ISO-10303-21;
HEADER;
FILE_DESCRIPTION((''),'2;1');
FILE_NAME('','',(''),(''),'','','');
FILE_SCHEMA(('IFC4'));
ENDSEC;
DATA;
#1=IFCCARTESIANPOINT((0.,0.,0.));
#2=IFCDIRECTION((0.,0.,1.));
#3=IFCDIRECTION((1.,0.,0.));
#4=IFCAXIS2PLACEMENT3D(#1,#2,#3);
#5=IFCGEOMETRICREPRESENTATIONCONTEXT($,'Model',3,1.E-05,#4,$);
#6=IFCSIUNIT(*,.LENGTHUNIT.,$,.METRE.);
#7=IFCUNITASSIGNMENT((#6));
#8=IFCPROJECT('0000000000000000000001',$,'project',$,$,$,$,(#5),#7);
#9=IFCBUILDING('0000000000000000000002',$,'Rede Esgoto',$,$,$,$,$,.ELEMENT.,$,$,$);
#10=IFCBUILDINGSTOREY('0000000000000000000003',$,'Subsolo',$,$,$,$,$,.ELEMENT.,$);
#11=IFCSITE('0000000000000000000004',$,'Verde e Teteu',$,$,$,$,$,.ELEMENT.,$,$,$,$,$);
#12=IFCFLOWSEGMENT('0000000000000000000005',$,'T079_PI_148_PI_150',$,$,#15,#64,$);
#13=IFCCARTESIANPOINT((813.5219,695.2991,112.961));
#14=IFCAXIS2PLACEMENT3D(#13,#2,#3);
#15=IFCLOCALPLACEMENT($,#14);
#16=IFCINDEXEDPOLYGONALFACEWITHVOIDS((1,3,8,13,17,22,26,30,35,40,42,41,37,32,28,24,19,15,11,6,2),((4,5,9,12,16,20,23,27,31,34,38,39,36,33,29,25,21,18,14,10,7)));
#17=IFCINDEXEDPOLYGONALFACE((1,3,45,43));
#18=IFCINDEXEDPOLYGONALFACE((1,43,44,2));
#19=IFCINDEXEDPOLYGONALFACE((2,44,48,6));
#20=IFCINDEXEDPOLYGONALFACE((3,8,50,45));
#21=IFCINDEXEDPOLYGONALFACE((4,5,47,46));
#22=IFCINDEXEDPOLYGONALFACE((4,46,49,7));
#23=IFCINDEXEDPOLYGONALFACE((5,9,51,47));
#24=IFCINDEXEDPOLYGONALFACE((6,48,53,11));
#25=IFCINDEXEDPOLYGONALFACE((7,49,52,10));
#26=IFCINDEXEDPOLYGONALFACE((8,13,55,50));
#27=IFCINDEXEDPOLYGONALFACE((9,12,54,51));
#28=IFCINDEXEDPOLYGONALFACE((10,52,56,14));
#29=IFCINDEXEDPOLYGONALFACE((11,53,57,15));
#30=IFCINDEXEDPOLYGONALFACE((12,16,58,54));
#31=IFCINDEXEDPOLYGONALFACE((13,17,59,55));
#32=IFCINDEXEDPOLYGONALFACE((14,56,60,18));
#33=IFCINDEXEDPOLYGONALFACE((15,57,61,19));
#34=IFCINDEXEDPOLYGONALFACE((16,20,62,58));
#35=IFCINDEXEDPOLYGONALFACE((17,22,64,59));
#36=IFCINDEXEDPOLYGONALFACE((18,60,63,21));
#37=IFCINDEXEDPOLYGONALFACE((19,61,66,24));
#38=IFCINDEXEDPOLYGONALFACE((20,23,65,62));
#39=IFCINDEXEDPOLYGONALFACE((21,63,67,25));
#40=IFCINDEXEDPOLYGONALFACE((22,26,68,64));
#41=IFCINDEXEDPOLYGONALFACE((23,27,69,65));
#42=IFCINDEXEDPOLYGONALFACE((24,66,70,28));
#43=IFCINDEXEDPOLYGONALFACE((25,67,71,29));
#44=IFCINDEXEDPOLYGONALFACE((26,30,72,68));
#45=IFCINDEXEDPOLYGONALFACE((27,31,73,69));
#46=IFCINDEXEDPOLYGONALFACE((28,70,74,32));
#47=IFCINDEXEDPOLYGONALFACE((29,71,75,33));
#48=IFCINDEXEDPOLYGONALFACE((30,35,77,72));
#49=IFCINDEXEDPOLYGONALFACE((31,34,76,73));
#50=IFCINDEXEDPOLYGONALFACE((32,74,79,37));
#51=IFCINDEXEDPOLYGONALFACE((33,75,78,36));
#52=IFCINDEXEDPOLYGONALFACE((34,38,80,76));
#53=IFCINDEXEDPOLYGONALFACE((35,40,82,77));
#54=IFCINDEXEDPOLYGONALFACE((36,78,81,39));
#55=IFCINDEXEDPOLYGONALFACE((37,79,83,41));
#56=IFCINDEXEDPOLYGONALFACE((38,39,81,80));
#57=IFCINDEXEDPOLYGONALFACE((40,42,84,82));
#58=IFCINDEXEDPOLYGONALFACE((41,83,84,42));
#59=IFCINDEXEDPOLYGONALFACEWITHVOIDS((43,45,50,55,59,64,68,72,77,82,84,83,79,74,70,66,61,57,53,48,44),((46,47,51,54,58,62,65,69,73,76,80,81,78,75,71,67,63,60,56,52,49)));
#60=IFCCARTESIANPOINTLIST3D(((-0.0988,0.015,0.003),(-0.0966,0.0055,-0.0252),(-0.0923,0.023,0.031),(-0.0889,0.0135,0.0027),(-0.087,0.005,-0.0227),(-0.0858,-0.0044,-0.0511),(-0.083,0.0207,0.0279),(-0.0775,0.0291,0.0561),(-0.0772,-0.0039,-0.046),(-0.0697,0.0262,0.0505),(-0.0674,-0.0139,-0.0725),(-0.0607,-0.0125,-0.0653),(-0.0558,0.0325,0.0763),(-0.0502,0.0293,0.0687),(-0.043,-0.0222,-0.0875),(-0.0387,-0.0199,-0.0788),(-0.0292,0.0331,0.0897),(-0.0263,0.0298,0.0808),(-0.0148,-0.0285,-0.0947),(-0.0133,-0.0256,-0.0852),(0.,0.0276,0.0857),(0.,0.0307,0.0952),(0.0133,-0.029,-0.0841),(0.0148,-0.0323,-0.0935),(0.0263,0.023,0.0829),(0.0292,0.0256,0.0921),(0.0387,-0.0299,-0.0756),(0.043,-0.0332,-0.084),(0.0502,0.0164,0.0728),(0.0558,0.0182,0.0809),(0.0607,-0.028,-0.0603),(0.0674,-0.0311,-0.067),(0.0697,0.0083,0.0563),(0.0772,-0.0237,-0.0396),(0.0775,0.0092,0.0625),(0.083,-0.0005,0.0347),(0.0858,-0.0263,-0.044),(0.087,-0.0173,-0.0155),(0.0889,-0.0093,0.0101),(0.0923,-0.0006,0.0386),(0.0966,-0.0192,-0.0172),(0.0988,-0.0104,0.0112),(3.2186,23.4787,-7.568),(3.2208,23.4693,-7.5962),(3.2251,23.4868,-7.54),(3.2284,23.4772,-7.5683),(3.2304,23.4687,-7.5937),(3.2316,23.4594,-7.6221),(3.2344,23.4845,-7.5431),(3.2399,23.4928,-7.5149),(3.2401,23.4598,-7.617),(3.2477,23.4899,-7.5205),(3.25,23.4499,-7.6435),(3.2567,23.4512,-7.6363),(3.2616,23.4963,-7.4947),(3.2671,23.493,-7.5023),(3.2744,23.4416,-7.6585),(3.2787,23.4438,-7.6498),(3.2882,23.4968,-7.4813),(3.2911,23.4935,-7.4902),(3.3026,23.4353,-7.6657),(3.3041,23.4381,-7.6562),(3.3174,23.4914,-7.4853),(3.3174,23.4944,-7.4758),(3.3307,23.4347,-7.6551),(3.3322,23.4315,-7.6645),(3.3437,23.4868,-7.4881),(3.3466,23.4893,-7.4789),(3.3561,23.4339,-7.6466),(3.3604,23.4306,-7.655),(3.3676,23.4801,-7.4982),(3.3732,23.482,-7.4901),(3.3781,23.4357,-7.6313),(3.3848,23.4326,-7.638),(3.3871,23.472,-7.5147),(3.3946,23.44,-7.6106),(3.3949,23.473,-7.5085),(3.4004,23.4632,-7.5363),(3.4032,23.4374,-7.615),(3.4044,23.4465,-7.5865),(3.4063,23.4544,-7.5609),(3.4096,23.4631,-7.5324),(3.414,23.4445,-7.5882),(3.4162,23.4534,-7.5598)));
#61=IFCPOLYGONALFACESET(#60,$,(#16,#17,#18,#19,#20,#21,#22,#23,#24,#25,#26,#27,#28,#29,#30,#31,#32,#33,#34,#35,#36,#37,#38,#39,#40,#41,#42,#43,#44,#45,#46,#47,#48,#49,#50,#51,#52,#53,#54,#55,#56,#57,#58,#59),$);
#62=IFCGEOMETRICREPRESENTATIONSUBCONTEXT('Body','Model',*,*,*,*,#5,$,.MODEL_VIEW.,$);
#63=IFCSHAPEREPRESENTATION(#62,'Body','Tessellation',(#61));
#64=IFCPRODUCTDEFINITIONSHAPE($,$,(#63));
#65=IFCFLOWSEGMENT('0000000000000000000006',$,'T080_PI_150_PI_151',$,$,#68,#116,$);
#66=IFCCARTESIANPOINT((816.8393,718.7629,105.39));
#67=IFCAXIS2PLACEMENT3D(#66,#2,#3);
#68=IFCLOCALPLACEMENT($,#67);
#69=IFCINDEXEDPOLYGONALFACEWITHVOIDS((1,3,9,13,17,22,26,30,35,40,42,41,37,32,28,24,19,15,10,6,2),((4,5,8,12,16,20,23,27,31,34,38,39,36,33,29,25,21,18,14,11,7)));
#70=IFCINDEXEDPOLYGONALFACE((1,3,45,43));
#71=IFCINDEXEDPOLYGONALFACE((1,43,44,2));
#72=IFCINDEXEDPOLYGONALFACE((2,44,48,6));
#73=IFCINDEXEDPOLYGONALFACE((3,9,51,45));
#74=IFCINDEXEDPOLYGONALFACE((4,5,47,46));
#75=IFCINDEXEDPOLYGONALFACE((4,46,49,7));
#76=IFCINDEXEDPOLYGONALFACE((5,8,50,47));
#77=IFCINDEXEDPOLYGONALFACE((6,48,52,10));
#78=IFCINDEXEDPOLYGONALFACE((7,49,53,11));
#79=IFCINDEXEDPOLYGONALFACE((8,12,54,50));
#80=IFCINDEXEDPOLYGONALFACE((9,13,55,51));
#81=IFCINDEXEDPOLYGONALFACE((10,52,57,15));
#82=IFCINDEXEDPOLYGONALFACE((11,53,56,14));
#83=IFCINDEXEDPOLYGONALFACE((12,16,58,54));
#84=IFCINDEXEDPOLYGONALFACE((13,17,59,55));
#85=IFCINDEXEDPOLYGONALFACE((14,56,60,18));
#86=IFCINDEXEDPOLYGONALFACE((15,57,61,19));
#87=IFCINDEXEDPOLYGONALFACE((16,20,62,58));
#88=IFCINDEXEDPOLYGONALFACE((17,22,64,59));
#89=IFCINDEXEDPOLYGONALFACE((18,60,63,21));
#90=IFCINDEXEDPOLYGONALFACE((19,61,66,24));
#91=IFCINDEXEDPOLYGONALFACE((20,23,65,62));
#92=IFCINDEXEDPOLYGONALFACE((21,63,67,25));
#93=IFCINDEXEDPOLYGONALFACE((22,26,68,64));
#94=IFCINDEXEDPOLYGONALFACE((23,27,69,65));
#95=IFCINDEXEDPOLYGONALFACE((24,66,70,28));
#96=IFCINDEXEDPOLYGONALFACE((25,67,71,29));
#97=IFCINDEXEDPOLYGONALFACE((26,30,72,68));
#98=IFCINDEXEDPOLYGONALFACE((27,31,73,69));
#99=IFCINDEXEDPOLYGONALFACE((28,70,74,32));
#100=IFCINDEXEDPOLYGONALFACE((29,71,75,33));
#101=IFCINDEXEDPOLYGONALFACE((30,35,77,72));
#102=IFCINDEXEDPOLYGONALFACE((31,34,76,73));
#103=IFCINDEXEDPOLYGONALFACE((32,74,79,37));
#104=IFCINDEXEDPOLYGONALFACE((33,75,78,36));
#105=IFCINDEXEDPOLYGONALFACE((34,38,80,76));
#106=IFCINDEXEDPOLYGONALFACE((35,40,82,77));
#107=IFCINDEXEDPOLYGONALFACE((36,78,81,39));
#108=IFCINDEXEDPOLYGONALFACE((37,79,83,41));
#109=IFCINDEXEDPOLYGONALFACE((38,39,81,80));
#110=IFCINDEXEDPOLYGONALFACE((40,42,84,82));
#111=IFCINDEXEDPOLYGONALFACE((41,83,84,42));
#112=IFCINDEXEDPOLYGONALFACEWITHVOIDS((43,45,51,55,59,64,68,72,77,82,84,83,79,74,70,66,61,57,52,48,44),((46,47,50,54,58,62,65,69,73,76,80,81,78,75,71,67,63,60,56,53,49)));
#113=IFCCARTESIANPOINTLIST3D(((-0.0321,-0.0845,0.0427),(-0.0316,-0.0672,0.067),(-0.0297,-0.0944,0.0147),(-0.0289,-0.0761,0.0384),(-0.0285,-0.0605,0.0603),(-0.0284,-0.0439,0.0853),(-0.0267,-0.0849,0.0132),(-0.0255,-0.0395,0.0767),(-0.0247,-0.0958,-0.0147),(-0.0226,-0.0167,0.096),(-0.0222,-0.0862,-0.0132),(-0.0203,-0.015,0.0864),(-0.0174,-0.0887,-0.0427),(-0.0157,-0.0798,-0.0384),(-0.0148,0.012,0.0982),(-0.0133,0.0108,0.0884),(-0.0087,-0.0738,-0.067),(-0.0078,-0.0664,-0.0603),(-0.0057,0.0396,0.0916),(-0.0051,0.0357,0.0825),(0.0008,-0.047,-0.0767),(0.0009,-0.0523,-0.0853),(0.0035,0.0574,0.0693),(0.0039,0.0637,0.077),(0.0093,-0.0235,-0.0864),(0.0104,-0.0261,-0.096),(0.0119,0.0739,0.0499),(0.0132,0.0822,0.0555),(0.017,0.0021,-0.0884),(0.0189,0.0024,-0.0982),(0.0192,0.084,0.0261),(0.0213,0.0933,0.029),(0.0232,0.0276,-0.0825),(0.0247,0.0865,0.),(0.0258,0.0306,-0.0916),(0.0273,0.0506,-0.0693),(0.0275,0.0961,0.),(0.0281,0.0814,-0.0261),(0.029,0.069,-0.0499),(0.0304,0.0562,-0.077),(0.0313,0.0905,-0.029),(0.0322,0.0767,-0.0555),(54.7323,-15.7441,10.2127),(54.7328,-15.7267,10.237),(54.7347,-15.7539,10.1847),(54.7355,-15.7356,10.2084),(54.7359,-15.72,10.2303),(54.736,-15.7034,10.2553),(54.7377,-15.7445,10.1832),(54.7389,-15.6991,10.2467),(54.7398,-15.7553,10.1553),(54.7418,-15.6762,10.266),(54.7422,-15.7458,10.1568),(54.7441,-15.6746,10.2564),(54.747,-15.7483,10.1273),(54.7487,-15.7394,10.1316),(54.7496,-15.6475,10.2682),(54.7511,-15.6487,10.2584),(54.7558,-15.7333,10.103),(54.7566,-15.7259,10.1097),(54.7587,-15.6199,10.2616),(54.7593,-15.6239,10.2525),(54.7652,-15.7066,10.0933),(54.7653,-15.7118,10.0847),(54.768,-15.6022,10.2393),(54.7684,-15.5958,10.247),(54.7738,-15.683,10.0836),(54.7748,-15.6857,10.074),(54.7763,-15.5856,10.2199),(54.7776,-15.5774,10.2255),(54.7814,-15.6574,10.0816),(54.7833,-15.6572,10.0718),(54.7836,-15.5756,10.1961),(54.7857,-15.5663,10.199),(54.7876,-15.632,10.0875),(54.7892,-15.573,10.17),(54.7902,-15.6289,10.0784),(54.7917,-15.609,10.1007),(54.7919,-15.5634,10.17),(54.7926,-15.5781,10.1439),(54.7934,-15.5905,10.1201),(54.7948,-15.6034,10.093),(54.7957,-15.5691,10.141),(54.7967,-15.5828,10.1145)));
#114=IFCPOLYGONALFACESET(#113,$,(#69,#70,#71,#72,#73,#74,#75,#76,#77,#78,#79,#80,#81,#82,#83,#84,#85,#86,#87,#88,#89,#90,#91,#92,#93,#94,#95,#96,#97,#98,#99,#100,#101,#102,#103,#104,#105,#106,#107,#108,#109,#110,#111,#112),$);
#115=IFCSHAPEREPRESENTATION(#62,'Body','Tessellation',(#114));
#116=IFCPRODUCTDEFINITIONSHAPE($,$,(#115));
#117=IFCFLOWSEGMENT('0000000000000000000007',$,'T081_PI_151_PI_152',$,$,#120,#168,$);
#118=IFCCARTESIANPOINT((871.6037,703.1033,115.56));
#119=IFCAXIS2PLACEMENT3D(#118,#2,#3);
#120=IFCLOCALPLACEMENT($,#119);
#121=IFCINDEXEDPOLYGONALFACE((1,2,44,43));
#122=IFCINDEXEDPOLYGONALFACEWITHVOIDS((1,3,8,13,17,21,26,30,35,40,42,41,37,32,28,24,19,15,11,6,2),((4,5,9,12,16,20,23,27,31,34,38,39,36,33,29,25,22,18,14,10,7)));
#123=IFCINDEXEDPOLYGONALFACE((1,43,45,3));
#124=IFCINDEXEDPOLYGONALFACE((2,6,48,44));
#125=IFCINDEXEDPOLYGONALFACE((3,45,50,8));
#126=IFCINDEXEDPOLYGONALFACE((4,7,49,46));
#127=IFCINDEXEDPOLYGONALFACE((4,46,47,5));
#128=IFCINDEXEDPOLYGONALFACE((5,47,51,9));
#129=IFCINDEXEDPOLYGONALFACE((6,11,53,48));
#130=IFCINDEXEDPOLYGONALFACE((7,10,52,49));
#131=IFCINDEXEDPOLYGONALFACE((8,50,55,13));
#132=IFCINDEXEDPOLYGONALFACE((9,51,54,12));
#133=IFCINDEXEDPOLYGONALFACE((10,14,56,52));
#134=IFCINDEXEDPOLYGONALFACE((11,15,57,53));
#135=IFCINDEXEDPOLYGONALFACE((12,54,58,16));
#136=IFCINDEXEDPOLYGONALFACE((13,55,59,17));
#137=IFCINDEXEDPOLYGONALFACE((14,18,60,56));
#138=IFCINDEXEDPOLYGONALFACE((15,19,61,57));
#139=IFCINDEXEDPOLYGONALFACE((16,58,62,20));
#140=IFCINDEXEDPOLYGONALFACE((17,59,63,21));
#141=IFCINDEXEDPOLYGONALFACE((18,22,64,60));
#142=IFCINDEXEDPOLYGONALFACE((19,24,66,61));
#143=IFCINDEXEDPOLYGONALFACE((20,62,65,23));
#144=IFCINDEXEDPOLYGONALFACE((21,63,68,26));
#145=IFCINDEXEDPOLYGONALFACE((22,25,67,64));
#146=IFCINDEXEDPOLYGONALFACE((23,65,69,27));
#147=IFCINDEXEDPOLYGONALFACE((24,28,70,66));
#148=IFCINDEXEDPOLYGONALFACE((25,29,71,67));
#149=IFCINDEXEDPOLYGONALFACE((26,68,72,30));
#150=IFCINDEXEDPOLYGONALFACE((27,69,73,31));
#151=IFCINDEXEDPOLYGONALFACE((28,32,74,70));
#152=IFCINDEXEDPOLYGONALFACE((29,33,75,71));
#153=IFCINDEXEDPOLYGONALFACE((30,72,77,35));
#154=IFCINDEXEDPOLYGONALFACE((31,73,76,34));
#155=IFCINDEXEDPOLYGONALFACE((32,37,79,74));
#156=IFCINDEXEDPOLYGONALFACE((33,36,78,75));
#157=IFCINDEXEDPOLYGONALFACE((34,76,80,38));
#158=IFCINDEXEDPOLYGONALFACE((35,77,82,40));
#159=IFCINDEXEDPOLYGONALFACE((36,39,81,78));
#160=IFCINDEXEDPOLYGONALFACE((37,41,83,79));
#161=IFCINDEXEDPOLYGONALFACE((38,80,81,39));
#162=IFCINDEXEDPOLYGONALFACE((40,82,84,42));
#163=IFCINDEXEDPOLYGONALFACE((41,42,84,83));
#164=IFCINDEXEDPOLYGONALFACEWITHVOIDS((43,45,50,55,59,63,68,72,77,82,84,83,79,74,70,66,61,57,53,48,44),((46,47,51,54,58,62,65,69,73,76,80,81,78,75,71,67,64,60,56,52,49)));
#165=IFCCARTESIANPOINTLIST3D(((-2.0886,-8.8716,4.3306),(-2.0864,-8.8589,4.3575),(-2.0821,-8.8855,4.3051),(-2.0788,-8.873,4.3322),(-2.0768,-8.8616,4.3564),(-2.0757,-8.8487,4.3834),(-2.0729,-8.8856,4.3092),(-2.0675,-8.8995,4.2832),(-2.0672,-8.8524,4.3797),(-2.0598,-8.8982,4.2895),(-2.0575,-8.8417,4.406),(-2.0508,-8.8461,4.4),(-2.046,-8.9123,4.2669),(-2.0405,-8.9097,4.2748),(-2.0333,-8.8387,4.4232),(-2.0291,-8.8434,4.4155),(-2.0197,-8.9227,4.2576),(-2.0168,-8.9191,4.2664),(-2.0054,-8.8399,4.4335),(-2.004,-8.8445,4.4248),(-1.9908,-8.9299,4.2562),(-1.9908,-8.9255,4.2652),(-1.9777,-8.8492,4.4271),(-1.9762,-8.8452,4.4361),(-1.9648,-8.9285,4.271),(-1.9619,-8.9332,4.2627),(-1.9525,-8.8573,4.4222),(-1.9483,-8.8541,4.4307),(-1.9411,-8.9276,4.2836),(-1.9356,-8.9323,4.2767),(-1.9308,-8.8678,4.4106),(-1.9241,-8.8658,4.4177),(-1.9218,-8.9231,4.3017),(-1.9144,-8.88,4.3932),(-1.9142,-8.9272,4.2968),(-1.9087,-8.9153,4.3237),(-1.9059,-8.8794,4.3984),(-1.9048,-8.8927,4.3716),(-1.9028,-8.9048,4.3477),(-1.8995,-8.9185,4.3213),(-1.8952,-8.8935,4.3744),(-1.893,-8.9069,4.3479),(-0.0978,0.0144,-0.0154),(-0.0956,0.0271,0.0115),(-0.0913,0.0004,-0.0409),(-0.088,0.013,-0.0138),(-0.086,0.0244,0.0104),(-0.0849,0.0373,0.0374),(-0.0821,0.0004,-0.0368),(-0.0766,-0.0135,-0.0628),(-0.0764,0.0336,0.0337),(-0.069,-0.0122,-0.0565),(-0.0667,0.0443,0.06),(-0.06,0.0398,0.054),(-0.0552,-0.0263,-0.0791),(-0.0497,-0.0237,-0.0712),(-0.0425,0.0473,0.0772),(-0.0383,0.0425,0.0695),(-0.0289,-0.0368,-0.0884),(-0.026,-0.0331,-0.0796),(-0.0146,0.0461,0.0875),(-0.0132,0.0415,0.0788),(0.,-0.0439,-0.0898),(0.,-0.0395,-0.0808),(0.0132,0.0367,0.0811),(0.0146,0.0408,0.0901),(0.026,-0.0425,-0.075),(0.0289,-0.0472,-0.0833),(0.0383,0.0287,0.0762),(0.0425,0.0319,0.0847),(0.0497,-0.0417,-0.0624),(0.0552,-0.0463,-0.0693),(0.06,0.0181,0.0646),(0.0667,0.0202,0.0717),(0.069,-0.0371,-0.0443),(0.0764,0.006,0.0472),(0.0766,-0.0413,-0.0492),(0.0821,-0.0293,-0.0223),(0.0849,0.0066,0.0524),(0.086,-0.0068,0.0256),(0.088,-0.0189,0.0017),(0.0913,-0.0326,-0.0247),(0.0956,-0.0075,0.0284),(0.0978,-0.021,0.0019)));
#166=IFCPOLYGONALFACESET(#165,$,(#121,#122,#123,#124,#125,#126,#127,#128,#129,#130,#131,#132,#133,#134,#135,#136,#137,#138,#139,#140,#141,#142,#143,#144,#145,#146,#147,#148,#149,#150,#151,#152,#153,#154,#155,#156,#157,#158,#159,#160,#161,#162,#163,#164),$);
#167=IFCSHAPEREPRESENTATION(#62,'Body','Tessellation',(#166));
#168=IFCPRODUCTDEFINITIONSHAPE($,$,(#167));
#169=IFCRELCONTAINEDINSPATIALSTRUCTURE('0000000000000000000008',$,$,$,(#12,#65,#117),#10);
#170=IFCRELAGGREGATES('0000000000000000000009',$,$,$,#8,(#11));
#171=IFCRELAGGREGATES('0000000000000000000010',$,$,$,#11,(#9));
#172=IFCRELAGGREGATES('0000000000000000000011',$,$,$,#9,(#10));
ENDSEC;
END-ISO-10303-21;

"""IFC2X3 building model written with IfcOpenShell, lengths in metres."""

from ifc_helpers import new_model, entity, si_unit, frame, origin_with_axes, place, context, subcontext, project, spatial, element, save


model = new_model("IFC2X3")

# Units and contexts
model_context = context("Model", 3, precision=1e-05, world=origin_with_axes())
body_context = subcontext(model_context, "Body", "Model", "MODEL_VIEW")
ifc_project = project(units=[si_unit("LENGTHUNIT", "METRE")], contexts=[model_context])

# Site, building, storey
site = spatial("IfcSite", under=ifc_project, Name="Verde e Teteu", CompositionType="ELEMENT")
building = spatial("IfcBuilding", under=site, Name="Rede Esgoto", CompositionType="ELEMENT")
storey = spatial("IfcBuildingStorey", under=building, Name="Subsolo", CompositionType="ELEMENT")

# Flow segments
flow_segment_1_placement = place(None, frame((813.5219, 695.2991, 112.961), z_axis=(0.0, 0.0, 1.0), x_axis=(1.0, 0.0, 0.0)))
element("IfcFlowSegment", 1, at=flow_segment_1_placement, inside=storey, Name="T079_PI_148_PI_150", context=body_context, shape_type="SweptSolid", body=[
    entity("IfcSweptDiskSolid", entity("IfcPolyline", [entity("IfcCartesianPoint", [0.0, 0.0, 0.0]), entity("IfcCartesianPoint", [3.3174, 23.4637, -7.571])]), 0.1, 0.09),
])
flow_segment_2_placement = place(None, frame((816.8393, 718.7629, 105.39), z_axis=(0.0, 0.0, 1.0), x_axis=(1.0, 0.0, 0.0)))
element("IfcFlowSegment", 2, at=flow_segment_2_placement, inside=storey, Name="T080_PI_150_PI_151", context=body_context, shape_type="SweptSolid", body=[
    entity("IfcSweptDiskSolid", entity("IfcPolyline", [entity("IfcCartesianPoint", [0.0, 0.0, 0.0]), entity("IfcCartesianPoint", [54.7644, -15.6596, 10.17])]), 0.1, 0.09),
])
flow_segment_3_placement = place(None, frame((871.6037, 703.1033, 115.56), z_axis=(0.0, 0.0, 1.0), x_axis=(1.0, 0.0, 0.0)))
element("IfcFlowSegment", 3, at=flow_segment_3_placement, inside=storey, Name="T081_PI_151_PI_152", context=body_context, shape_type="SweptSolid", body=[
    entity("IfcSweptDiskSolid", entity("IfcPolyline", [entity("IfcCartesianPoint", [0.0, 0.0, 0.0]), entity("IfcCartesianPoint", [-1.9908, -8.886, 4.346])]), 0.1, 0.09),
])

save(model, "model.ifc")
